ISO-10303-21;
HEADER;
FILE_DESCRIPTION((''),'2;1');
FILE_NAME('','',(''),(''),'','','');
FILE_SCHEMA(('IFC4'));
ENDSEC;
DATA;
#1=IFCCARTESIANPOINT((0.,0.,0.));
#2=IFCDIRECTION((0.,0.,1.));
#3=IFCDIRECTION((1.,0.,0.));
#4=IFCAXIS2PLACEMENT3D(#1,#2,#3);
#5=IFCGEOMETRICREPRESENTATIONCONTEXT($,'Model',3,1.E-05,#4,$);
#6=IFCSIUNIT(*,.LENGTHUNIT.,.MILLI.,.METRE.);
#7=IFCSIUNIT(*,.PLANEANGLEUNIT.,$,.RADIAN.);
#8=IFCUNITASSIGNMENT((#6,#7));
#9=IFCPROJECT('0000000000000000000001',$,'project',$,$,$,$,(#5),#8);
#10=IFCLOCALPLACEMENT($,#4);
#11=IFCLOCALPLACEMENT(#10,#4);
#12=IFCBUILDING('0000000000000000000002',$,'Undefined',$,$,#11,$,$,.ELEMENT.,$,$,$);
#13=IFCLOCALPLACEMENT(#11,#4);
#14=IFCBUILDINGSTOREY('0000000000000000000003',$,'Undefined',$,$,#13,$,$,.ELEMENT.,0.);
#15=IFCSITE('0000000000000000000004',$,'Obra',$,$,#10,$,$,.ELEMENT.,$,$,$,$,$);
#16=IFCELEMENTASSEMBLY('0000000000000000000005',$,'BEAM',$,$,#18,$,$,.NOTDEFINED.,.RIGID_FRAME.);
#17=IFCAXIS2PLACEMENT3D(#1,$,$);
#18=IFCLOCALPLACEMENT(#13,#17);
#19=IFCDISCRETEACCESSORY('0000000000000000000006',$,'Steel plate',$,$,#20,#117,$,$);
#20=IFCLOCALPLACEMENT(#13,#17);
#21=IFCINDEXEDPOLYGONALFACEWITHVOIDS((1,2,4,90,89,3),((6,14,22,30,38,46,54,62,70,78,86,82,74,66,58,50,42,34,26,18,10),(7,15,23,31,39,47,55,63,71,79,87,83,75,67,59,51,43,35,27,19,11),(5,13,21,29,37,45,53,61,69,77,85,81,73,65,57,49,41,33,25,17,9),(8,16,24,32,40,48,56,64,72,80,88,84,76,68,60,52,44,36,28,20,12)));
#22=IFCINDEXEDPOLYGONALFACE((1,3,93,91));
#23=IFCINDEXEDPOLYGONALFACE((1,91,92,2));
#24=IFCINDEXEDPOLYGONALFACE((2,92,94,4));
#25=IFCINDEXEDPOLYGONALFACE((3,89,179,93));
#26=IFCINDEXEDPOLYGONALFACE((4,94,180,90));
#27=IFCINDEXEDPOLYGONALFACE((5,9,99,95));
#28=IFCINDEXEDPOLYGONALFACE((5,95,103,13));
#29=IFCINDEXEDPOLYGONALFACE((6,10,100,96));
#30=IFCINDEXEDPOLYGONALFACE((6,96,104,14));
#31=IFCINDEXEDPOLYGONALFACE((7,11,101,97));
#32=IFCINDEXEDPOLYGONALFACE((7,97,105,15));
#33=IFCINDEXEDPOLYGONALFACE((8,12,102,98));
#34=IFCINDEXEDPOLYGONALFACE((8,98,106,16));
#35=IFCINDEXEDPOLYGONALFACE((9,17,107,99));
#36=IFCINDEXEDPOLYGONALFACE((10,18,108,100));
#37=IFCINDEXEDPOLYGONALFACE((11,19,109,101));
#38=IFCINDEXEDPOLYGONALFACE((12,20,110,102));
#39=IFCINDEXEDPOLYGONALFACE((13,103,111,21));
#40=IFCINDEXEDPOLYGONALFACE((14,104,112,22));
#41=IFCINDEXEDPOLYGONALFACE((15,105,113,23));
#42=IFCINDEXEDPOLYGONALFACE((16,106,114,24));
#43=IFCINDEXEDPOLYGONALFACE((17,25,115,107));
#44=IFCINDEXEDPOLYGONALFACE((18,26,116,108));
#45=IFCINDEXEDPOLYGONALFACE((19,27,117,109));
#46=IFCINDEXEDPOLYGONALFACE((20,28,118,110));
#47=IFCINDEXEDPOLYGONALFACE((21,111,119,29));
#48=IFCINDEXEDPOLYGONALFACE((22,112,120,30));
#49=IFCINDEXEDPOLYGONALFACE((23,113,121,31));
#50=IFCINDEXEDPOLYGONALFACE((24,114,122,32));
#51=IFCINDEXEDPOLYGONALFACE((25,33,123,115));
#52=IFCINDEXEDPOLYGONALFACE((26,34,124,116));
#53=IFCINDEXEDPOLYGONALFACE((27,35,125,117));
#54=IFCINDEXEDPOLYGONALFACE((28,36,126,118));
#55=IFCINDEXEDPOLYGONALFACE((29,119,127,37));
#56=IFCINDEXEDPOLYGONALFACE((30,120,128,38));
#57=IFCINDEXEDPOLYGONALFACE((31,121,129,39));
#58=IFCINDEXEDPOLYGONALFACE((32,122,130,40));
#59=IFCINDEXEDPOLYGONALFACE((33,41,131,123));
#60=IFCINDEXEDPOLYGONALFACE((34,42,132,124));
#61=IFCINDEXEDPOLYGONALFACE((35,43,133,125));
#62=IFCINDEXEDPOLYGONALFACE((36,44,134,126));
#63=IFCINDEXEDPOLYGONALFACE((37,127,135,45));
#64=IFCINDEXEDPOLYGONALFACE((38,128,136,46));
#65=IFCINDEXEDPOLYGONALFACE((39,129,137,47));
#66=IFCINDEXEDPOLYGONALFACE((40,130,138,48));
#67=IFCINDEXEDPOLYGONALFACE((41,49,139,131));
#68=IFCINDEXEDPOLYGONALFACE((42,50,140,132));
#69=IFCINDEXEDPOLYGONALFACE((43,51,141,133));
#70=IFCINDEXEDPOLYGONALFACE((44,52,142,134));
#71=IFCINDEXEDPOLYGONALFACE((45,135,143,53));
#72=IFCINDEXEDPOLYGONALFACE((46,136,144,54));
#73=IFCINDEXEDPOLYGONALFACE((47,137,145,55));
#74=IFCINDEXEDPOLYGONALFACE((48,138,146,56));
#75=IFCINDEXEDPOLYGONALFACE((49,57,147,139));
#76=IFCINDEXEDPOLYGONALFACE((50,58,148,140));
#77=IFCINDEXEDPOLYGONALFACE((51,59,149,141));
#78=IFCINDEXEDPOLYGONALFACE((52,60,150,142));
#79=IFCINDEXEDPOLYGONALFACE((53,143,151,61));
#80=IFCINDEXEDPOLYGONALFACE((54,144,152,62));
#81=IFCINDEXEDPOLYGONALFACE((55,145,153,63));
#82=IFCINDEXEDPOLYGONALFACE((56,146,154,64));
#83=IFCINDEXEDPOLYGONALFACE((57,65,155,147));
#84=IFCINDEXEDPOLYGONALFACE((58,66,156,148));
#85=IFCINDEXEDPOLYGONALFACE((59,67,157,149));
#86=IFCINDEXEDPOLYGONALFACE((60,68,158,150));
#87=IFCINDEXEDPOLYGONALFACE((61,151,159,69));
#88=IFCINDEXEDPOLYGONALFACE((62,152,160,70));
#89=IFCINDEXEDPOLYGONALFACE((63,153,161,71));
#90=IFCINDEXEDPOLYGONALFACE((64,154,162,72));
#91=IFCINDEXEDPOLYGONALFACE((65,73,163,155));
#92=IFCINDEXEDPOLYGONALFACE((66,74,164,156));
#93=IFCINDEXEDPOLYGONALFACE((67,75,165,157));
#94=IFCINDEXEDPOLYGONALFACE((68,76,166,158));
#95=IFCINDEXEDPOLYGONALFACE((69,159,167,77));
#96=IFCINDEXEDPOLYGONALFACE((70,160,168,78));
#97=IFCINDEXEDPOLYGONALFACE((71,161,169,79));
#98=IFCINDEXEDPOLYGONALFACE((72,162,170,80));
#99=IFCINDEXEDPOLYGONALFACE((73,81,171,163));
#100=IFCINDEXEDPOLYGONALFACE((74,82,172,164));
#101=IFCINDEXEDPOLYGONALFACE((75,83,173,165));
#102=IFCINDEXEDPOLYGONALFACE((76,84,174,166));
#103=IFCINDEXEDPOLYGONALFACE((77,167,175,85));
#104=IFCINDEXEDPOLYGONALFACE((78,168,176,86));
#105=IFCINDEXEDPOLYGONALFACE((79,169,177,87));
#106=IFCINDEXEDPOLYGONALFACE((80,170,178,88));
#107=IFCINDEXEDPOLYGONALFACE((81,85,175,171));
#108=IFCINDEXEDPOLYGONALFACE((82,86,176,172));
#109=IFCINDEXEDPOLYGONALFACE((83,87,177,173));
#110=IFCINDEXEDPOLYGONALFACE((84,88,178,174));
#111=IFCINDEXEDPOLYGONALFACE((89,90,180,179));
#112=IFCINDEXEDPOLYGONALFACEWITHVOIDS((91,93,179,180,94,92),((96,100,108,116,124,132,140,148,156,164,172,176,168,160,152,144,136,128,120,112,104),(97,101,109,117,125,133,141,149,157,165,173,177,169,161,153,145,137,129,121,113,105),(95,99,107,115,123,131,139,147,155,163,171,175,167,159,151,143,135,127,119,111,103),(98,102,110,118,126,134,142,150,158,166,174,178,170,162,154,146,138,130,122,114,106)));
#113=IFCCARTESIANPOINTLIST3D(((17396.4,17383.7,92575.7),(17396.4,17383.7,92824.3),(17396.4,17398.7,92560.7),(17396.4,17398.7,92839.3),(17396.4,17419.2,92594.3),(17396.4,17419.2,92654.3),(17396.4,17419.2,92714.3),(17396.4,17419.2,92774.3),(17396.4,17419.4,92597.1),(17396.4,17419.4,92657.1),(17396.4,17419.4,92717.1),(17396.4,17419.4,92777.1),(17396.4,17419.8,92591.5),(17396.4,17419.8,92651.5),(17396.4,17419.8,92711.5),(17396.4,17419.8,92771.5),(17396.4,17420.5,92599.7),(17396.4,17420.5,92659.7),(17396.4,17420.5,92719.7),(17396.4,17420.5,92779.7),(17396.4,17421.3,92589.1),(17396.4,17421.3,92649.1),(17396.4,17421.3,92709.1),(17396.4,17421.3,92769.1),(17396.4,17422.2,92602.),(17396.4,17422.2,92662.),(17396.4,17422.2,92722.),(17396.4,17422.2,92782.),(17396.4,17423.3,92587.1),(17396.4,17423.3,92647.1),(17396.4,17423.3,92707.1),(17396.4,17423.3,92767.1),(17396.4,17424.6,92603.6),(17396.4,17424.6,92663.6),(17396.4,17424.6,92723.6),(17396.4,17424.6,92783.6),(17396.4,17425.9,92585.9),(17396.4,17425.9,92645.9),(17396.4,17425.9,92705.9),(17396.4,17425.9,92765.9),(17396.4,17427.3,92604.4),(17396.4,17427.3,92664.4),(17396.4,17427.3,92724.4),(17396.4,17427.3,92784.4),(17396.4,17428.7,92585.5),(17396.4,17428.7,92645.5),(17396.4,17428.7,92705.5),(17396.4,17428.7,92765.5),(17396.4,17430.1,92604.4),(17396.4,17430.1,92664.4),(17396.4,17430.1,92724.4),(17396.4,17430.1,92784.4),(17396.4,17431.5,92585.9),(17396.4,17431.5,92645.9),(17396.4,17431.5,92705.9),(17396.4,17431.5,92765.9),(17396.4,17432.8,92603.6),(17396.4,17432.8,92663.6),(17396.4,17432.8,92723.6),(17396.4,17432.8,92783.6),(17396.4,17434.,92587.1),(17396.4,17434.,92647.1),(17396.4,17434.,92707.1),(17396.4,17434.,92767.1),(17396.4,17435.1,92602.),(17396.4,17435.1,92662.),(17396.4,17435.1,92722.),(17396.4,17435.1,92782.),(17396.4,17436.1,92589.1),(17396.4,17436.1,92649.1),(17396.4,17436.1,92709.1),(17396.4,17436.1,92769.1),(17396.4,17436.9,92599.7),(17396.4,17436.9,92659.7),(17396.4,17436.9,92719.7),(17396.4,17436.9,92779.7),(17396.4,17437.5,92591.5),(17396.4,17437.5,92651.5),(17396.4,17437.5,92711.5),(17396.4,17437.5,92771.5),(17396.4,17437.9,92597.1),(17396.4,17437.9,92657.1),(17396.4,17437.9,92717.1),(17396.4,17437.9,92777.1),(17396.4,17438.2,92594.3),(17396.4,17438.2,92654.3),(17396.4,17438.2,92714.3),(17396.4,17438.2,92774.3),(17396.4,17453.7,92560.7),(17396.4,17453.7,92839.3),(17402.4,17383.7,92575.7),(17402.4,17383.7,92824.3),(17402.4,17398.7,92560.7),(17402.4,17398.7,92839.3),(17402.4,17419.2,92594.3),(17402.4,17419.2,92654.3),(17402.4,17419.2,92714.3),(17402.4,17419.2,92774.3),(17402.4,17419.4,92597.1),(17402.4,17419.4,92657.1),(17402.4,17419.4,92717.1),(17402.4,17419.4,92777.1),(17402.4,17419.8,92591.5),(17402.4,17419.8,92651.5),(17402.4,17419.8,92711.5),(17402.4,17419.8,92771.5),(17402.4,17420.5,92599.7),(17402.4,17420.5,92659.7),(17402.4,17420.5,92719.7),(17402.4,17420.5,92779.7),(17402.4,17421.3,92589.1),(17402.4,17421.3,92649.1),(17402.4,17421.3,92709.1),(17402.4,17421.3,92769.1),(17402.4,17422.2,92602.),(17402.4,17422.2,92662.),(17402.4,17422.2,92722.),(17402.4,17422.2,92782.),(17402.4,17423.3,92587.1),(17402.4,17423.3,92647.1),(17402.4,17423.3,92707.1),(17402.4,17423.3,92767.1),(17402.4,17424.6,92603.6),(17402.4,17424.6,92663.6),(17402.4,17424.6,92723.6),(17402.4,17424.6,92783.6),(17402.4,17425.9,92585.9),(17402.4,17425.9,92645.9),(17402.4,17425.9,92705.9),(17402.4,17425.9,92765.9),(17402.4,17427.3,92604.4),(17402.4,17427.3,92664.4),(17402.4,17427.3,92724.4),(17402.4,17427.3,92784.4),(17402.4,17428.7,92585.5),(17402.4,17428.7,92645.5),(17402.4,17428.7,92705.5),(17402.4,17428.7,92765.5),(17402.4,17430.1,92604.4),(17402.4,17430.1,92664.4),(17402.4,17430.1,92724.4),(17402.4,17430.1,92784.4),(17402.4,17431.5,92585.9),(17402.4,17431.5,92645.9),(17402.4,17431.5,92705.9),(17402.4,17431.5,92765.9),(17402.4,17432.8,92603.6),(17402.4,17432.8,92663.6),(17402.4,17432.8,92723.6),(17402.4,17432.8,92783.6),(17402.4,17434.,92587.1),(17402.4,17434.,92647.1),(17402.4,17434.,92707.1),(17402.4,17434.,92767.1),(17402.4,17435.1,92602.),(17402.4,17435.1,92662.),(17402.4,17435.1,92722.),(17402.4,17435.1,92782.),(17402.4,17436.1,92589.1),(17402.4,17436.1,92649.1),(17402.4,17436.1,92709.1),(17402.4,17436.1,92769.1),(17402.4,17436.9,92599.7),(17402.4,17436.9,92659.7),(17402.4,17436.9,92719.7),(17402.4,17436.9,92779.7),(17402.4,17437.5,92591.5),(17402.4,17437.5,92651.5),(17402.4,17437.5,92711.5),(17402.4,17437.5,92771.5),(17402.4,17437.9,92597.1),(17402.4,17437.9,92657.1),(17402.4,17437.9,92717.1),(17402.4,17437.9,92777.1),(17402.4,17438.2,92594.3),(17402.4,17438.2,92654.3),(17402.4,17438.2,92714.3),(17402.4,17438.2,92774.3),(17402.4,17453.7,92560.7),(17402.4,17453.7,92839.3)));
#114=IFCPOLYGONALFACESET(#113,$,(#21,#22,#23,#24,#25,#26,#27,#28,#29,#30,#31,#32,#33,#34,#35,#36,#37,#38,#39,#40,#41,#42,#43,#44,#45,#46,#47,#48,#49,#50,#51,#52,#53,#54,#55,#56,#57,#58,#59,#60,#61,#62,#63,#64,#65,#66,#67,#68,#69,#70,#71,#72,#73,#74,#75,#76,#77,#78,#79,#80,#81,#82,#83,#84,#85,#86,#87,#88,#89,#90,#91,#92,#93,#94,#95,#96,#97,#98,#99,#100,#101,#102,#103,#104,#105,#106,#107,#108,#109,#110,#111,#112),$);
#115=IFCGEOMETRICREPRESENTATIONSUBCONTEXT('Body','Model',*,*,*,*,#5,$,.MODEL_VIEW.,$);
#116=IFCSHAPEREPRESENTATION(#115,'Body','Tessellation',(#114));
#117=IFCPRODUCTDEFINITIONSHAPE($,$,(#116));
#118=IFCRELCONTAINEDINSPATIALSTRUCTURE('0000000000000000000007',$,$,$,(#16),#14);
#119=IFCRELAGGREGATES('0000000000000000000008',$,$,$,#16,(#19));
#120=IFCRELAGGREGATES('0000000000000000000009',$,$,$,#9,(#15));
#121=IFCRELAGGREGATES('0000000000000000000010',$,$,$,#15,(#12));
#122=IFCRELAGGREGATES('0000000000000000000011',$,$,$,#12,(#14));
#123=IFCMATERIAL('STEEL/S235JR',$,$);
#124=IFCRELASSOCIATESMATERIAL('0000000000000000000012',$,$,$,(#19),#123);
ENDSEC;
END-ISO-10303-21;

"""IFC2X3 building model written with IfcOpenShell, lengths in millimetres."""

from ifc_helpers import new_model, si_unit, frame, origin_with_axes, origin_2d_with_axis, place, context, subcontext, project, spatial, polyline, circle, outline, extrude, source, transform, mapped, material, element, aggregate, save


model = new_model("IFC2X3")

# Units and contexts
model_context = context("Model", 3, precision=1e-05, world=origin_with_axes())
body_context = subcontext(model_context, "Body", "Model", "MODEL_VIEW")
ifc_project = project(units=[si_unit("LENGTHUNIT", "METRE", prefix="MILLI"), si_unit("PLANEANGLEUNIT", "RADIAN")], contexts=[model_context])

# Site, building, storey
site_placement = place(None, origin_with_axes())
site = spatial("IfcSite", under=ifc_project, at=site_placement, Name="Obra", CompositionType="ELEMENT")
building_placement = place(site_placement, origin_with_axes())
building = spatial("IfcBuilding", under=site, at=building_placement, Name="Undefined", CompositionType="ELEMENT")
storey_placement = place(building_placement, origin_with_axes())
storey = spatial("IfcBuildingStorey", under=building, at=storey_placement, Name="Undefined", CompositionType="ELEMENT", Elevation=0.0)

# Element assembly, discrete accessory, opening
assembly_1_placement = place(storey_placement, origin_with_axes())
assembly_1 = element("IfcElementAssembly", 1, at=assembly_1_placement, inside=storey, Name="BEAM", AssemblyPlace="NOTDEFINED", PredefinedType="RIGID_FRAME")
ifc_material_1 = material(Name="STEEL/S235JR")
discrete_accessory_1_placement = place(assembly_1_placement, frame((17399.4, 17453.7, 92560.7), z_axis=(-1.0, 0.0, 0.0), x_axis=(0.0, -1.0, 0.0)))
discrete_accessory_1 = element("IfcDiscreteAccessory", 2, at=discrete_accessory_1_placement, material=ifc_material_1, Name="Steel plate", context=body_context, shape_type="SweptSolid", body=[
    extrude(outline(polyline([(0.0, 0.0), (55.0, 0.0), (70.0, 15.0), (70.0, 263.6), (55.0, 278.6), (0.0, 278.6), (0.0, 0.0)])), frame((0.0, 0.0, -3.0), z_axis=(0.0, 0.0, 1.0), x_axis=(1.0, 0.0, 0.0)), (0.0, 0.0, 1.0), 6.0),
])
shared_shape_1 = source(origin_with_axes(), body_context, "Body", "SweptSolid", [
    extrude(circle(Radius=9.5, at=origin_2d_with_axis()), frame((0.0, -9.8, 0.0), z_axis=(0.0, 1.0, 0.0), x_axis=(1.0, 0.0, 0.0)), (0.0, 0.0, 1.0), 6.2),
])
opening_1_placement = place(assembly_1_placement, frame((17392.7, 17393.7, 92850.0), z_axis=(0.0, 1.0, 0.0), x_axis=(0.0, 0.0, -1.0)))
element("IfcOpeningElement", 3, at=opening_1_placement, cuts=discrete_accessory_1, ObjectType="Opening", context=body_context, shape_type="MappedRepresentation", body=[
    mapped(shared_shape_1, transform((75.0, 0.0, 35.0))),
    mapped(shared_shape_1, transform((135.0, 0.0, 35.0))),
    mapped(shared_shape_1, transform((195.0, 0.0, 35.0))),
    mapped(shared_shape_1, transform((255.0, 0.0, 35.0))),
])

aggregate(assembly_1, [discrete_accessory_1])

save(model, "model.ifc")
